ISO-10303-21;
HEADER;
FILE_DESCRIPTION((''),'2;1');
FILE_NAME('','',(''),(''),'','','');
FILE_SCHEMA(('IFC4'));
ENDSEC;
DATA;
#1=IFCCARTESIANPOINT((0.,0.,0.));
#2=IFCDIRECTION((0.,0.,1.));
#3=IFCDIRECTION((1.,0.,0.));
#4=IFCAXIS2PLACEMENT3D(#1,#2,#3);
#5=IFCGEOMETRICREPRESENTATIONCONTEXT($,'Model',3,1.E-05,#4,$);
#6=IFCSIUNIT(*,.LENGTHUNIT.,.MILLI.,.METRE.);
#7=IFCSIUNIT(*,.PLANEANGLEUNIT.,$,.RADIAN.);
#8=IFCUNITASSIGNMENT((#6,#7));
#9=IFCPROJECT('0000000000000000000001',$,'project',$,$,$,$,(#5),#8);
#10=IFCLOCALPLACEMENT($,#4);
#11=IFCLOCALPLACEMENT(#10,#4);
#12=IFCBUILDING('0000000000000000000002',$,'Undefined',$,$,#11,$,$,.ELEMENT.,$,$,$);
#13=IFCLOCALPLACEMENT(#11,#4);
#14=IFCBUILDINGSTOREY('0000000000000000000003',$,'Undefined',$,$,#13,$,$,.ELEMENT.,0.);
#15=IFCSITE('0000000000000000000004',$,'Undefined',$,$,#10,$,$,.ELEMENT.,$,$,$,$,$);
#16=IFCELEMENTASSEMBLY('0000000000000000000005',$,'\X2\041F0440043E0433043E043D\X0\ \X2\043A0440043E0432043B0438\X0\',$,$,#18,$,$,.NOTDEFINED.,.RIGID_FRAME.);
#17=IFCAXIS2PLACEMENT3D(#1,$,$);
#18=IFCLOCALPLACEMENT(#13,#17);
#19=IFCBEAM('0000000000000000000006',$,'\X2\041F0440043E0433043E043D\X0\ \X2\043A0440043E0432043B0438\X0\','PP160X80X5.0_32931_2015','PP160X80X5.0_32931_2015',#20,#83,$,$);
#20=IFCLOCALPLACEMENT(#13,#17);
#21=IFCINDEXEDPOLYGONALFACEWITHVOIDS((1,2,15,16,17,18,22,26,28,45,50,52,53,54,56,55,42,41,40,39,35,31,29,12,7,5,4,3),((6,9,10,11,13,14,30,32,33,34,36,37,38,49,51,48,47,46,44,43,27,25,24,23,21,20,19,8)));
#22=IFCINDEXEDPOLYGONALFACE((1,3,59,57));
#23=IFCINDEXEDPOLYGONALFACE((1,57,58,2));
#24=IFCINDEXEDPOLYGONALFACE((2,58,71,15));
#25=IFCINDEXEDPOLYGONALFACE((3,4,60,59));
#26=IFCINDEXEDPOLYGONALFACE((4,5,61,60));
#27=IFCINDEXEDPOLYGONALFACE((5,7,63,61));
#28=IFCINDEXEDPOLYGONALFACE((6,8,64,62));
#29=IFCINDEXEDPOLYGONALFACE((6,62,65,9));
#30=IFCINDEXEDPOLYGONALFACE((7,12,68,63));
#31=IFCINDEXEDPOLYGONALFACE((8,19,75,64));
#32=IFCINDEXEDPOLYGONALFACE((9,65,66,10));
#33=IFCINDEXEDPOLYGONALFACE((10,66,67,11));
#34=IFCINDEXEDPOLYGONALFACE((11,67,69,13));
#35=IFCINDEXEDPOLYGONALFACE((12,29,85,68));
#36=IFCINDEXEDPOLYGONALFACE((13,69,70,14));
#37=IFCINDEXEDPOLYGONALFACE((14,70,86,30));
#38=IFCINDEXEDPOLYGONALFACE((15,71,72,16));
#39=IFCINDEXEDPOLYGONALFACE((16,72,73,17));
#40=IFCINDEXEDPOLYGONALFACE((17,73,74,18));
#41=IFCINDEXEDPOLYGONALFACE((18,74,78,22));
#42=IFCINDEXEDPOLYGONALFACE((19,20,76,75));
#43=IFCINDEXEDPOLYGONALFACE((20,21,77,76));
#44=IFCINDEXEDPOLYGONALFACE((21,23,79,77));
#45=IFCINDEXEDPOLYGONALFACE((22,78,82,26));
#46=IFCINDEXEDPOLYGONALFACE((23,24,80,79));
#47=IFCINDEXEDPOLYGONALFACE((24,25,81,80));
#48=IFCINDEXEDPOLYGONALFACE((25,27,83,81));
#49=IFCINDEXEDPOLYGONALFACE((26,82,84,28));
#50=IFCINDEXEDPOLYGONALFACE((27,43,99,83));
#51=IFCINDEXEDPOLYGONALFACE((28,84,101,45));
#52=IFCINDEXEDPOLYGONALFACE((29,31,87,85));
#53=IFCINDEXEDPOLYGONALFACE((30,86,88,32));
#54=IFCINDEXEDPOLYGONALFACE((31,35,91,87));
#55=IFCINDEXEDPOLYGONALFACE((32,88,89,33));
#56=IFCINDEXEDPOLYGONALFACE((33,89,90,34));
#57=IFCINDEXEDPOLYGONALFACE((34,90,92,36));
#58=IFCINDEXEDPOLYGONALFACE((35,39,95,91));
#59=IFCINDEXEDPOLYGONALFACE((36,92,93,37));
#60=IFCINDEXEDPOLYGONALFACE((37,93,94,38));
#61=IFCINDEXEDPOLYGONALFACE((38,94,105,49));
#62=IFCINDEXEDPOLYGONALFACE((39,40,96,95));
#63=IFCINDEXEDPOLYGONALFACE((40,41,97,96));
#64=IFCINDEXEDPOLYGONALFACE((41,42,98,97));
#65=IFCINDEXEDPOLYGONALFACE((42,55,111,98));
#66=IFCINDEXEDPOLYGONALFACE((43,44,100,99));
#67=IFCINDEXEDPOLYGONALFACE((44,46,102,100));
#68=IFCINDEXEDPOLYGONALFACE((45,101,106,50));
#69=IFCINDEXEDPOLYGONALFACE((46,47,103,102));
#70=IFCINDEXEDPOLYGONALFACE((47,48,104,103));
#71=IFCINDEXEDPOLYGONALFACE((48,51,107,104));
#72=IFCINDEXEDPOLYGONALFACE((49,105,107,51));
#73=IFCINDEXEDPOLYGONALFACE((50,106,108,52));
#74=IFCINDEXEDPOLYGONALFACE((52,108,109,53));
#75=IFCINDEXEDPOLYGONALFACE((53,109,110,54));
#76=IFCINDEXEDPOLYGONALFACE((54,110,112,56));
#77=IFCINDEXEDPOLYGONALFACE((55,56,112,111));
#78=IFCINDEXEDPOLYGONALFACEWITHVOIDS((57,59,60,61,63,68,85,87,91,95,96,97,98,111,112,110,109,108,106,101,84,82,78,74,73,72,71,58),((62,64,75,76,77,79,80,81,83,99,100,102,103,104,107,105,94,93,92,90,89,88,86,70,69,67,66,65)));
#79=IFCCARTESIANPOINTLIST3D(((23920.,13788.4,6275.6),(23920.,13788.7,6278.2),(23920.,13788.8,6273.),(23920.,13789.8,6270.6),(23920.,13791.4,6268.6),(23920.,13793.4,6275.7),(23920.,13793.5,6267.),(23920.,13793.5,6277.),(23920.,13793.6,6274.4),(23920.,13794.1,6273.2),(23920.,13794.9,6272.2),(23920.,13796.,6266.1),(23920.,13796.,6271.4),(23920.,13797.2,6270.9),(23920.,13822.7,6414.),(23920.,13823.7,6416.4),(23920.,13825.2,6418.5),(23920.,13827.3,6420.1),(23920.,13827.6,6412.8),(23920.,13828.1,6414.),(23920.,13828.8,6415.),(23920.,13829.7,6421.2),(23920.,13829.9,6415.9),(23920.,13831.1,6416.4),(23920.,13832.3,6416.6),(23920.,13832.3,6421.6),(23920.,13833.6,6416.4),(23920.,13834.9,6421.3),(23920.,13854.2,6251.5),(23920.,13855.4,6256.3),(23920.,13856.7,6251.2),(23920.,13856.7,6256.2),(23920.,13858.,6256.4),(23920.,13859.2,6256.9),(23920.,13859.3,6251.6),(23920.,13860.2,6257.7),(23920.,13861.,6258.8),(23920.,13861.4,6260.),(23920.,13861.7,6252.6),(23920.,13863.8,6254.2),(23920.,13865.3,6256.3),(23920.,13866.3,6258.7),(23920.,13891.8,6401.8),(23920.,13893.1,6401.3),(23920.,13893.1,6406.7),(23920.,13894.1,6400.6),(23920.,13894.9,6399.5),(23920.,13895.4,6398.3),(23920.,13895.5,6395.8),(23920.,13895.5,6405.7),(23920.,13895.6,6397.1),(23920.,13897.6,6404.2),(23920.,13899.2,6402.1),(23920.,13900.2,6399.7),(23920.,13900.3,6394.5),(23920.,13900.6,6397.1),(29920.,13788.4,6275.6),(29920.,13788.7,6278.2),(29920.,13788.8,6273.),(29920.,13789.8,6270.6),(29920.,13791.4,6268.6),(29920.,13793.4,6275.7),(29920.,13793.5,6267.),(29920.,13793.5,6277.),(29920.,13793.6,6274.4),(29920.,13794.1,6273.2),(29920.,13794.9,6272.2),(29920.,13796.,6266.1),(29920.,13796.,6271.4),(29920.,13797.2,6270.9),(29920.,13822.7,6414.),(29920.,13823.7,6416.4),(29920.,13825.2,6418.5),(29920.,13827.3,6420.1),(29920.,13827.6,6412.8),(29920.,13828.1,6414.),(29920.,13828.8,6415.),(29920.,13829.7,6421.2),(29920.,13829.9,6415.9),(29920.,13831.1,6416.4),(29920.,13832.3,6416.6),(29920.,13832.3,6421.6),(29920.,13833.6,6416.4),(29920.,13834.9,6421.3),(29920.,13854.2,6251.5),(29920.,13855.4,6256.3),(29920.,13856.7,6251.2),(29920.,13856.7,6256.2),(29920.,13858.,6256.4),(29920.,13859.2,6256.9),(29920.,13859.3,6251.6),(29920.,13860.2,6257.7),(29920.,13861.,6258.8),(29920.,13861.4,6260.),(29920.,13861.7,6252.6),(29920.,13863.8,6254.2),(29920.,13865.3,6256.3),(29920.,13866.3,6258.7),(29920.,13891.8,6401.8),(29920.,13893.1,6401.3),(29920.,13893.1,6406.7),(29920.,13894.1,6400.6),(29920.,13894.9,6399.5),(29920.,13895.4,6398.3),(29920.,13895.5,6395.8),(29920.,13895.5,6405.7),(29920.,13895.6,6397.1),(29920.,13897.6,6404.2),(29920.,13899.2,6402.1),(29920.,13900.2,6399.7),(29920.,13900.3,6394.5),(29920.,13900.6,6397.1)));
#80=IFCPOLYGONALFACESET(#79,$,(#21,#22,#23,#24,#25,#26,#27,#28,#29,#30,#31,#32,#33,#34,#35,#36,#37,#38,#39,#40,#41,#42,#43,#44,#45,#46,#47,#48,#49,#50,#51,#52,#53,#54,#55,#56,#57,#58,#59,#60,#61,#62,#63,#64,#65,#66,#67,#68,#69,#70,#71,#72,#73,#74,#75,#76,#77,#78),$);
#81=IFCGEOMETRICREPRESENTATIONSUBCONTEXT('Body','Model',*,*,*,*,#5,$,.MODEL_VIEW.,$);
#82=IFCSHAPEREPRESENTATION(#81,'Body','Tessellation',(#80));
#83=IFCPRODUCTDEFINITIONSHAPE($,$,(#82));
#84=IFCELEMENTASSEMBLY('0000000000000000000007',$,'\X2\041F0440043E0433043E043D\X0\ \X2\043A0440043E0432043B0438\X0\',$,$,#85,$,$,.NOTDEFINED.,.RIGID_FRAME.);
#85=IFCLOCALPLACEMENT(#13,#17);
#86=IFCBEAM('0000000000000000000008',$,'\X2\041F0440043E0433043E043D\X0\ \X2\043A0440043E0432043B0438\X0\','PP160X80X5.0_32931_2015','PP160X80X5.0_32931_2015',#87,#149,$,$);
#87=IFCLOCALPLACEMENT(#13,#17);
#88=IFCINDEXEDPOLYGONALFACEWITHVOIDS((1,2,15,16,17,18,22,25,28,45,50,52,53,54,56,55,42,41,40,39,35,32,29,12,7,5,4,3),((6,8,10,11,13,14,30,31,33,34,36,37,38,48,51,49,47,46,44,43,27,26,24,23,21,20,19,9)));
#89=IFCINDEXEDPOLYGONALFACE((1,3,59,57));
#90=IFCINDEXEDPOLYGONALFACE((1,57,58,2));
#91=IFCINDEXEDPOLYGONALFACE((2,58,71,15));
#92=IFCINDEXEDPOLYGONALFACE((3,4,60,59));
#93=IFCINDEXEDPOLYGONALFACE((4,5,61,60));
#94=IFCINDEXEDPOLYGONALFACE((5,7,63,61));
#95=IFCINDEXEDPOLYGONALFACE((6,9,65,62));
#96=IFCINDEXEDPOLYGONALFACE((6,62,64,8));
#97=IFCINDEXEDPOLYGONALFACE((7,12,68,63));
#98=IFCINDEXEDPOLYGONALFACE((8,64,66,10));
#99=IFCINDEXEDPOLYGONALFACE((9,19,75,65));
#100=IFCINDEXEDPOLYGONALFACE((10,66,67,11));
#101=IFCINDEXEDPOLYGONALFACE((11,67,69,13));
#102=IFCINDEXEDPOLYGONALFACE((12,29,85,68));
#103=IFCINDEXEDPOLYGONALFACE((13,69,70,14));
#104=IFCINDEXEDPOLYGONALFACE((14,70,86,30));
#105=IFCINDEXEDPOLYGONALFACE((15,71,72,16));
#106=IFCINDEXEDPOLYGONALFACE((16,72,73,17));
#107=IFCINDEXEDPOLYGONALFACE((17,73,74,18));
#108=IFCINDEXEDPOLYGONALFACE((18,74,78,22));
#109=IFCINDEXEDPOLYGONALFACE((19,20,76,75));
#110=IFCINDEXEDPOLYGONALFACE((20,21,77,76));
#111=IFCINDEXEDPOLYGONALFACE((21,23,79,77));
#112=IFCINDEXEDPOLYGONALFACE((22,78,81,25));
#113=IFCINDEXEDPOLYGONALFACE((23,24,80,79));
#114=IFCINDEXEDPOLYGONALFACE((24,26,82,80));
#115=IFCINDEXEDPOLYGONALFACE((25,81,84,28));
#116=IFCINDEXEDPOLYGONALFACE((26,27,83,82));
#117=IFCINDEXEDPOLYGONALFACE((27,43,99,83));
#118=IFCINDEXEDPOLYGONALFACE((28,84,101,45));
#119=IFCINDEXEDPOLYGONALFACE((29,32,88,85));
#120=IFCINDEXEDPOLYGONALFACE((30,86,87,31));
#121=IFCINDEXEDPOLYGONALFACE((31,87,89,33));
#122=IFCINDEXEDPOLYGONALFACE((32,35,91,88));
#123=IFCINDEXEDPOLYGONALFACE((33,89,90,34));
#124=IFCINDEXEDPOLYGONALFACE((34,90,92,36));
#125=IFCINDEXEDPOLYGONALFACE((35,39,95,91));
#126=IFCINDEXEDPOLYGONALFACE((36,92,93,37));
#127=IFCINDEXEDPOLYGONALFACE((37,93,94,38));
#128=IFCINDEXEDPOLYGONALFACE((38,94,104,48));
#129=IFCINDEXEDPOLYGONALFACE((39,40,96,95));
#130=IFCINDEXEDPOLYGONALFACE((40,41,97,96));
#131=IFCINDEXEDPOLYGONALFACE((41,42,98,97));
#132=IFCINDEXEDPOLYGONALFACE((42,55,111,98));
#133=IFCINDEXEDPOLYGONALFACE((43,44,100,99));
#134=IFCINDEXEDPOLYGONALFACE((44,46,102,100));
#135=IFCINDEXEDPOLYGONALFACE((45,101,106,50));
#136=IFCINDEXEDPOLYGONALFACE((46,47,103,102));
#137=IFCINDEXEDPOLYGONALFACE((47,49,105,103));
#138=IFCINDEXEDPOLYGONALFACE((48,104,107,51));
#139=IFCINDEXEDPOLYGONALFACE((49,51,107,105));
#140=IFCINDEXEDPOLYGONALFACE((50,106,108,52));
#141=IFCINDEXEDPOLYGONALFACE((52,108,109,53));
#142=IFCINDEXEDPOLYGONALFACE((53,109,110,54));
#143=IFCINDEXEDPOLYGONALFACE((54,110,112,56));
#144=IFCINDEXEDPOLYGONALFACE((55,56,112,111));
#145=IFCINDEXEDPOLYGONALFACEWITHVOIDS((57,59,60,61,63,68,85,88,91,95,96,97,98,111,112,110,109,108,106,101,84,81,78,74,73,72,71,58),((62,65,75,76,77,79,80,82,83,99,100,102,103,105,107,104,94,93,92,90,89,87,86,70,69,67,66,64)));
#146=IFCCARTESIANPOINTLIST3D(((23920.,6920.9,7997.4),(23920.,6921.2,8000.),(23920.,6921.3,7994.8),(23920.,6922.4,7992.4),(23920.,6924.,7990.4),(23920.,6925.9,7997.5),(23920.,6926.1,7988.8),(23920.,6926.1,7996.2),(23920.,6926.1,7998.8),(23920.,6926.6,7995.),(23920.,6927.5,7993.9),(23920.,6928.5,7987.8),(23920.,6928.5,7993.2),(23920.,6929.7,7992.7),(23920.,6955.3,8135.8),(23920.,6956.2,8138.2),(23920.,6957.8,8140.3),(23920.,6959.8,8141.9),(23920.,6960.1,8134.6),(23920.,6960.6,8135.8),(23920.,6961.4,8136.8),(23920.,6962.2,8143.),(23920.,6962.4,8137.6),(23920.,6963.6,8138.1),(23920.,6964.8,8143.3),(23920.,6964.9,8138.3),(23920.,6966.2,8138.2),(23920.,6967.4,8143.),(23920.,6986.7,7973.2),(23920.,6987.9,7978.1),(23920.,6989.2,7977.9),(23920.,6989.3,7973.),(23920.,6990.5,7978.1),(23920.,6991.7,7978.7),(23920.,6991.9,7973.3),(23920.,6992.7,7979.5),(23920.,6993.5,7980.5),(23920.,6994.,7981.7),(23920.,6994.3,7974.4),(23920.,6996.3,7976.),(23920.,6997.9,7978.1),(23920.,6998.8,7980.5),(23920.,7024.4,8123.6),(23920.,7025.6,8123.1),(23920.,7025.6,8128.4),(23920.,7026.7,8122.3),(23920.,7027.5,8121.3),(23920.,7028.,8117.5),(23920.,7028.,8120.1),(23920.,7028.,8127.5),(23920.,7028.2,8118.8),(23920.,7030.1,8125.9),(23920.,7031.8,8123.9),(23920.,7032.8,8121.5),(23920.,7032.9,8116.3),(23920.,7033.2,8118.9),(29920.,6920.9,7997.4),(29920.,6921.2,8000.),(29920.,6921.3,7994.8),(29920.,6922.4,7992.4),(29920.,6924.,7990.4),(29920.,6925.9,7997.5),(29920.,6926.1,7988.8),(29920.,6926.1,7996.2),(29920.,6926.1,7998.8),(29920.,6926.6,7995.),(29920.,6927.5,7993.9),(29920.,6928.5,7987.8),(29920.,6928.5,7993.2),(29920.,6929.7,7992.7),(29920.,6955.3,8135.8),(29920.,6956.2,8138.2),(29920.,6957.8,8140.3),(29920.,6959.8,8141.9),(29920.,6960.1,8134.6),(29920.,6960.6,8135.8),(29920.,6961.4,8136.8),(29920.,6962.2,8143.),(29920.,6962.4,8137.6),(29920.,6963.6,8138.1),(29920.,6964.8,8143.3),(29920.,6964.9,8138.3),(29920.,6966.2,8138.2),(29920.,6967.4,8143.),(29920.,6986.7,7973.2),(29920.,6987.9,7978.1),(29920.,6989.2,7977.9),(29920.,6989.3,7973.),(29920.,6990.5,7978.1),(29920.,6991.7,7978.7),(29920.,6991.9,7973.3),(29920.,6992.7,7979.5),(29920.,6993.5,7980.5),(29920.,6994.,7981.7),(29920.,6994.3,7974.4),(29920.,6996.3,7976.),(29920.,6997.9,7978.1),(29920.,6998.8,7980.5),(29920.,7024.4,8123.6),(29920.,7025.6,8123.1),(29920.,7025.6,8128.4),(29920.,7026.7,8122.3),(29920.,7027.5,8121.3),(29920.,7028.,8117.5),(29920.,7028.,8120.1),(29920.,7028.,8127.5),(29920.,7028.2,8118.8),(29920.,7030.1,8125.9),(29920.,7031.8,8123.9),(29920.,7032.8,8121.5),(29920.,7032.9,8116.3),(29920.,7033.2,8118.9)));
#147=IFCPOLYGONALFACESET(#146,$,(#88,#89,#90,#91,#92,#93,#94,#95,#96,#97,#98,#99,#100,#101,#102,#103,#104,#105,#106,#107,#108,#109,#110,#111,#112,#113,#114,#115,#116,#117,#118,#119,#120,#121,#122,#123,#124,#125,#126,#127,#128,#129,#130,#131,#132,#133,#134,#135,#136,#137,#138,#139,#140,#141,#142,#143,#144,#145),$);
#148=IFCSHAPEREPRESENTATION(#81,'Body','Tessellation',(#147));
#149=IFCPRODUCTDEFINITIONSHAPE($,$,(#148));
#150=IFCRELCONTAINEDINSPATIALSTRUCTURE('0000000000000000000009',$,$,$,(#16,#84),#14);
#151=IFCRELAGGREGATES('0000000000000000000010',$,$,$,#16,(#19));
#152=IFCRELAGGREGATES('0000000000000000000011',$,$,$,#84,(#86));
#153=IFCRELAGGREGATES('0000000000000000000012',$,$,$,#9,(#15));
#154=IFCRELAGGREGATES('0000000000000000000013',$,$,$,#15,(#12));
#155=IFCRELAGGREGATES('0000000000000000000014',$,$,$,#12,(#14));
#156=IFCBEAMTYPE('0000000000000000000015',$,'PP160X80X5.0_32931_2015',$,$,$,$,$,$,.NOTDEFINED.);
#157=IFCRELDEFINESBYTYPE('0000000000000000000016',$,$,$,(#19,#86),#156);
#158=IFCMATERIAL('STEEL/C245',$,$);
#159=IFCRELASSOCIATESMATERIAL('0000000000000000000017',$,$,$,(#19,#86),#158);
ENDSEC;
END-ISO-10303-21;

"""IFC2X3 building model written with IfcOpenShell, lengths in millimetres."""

from ifc_helpers import new_model, si_unit, frame, origin_with_axes, origin_2d_with_axis, place, context, subcontext, project, spatial, hollow_rectangle, extrude, material, type_object, element, aggregate, save


model = new_model("IFC2X3")

# Units and contexts
model_context = context("Model", 3, precision=1e-05, world=origin_with_axes())
body_context = subcontext(model_context, "Body", "Model", "MODEL_VIEW")
ifc_project = project(units=[si_unit("LENGTHUNIT", "METRE", prefix="MILLI"), si_unit("PLANEANGLEUNIT", "RADIAN")], contexts=[model_context])

# Site, building, storey
site_placement = place(None, origin_with_axes())
site = spatial("IfcSite", under=ifc_project, at=site_placement, Name="Undefined", CompositionType="ELEMENT")
building_placement = place(site_placement, origin_with_axes())
building = spatial("IfcBuilding", under=site, at=building_placement, Name="Undefined", CompositionType="ELEMENT")
storey_placement = place(building_placement, origin_with_axes())
storey = spatial("IfcBuildingStorey", under=building, at=storey_placement, Name="Undefined", CompositionType="ELEMENT", Elevation=0.0)

# Shared definitions
ifc_material = material(Name="STEEL/C245")

# Element assemblies, beams
assembly_1_placement = place(storey_placement, origin_with_axes())
assembly_1 = element("IfcElementAssembly", 1, at=assembly_1_placement, inside=storey, Name="Прогон кровли", AssemblyPlace="NOTDEFINED", PredefinedType="RIGID_FRAME")
beam_type_1 = type_object("IfcBeamType", Name="PP160X80X5.0_32931_2015", PredefinedType="NOTDEFINED")
beam_1_placement = place(assembly_1_placement, frame((23920.0, 13844.5, 6336.4), z_axis=(0.0, 0.243188, 0.969979), x_axis=(1.0, 0.0, 0.0)))
beam_1 = element("IfcBeam", 2, at=beam_1_placement, type_object=beam_type_1, material=ifc_material, Name="Прогон кровли", Description="PP160X80X5.0_32931_2015", ObjectType="PP160X80X5.0_32931_2015", context=body_context, shape_type="SweptSolid", body=[
    extrude(hollow_rectangle(XDim=80.0, YDim=160.0, WallThickness=5.0, InnerFilletRadius=5.0, OuterFilletRadius=10.0, at=origin_2d_with_axis()), frame((6000.0, 0.0, 0.0), z_axis=(-1.0, 0.0, 0.0), x_axis=(0.0, -1.0, 0.0)), (0.0, 0.0, 1.0), 6000.0),
])
aggregate(assembly_1, [beam_1])
assembly_2_placement = place(storey_placement, origin_with_axes())
assembly_2 = element("IfcElementAssembly", 3, at=assembly_2_placement, inside=storey, Name="Прогон кровли", AssemblyPlace="NOTDEFINED", PredefinedType="RIGID_FRAME")
beam_2_placement = place(assembly_2_placement, frame((23920.0, 6977.1, 8058.1), z_axis=(0.0, 0.243188, 0.969979), x_axis=(1.0, 0.0, 0.0)))
beam_2 = element("IfcBeam", 4, at=beam_2_placement, type_object=beam_type_1, material=ifc_material, Name="Прогон кровли", Description="PP160X80X5.0_32931_2015", ObjectType="PP160X80X5.0_32931_2015", context=body_context, shape_type="SweptSolid", body=[
    extrude(hollow_rectangle(XDim=80.0, YDim=160.0, WallThickness=5.0, InnerFilletRadius=5.0, OuterFilletRadius=10.0, at=origin_2d_with_axis()), frame((6000.0, 0.0, 0.0), z_axis=(-1.0, 0.0, 0.0), x_axis=(0.0, -1.0, 0.0)), (0.0, 0.0, 1.0), 6000.0),
])
aggregate(assembly_2, [beam_2])

save(model, "model.ifc")
